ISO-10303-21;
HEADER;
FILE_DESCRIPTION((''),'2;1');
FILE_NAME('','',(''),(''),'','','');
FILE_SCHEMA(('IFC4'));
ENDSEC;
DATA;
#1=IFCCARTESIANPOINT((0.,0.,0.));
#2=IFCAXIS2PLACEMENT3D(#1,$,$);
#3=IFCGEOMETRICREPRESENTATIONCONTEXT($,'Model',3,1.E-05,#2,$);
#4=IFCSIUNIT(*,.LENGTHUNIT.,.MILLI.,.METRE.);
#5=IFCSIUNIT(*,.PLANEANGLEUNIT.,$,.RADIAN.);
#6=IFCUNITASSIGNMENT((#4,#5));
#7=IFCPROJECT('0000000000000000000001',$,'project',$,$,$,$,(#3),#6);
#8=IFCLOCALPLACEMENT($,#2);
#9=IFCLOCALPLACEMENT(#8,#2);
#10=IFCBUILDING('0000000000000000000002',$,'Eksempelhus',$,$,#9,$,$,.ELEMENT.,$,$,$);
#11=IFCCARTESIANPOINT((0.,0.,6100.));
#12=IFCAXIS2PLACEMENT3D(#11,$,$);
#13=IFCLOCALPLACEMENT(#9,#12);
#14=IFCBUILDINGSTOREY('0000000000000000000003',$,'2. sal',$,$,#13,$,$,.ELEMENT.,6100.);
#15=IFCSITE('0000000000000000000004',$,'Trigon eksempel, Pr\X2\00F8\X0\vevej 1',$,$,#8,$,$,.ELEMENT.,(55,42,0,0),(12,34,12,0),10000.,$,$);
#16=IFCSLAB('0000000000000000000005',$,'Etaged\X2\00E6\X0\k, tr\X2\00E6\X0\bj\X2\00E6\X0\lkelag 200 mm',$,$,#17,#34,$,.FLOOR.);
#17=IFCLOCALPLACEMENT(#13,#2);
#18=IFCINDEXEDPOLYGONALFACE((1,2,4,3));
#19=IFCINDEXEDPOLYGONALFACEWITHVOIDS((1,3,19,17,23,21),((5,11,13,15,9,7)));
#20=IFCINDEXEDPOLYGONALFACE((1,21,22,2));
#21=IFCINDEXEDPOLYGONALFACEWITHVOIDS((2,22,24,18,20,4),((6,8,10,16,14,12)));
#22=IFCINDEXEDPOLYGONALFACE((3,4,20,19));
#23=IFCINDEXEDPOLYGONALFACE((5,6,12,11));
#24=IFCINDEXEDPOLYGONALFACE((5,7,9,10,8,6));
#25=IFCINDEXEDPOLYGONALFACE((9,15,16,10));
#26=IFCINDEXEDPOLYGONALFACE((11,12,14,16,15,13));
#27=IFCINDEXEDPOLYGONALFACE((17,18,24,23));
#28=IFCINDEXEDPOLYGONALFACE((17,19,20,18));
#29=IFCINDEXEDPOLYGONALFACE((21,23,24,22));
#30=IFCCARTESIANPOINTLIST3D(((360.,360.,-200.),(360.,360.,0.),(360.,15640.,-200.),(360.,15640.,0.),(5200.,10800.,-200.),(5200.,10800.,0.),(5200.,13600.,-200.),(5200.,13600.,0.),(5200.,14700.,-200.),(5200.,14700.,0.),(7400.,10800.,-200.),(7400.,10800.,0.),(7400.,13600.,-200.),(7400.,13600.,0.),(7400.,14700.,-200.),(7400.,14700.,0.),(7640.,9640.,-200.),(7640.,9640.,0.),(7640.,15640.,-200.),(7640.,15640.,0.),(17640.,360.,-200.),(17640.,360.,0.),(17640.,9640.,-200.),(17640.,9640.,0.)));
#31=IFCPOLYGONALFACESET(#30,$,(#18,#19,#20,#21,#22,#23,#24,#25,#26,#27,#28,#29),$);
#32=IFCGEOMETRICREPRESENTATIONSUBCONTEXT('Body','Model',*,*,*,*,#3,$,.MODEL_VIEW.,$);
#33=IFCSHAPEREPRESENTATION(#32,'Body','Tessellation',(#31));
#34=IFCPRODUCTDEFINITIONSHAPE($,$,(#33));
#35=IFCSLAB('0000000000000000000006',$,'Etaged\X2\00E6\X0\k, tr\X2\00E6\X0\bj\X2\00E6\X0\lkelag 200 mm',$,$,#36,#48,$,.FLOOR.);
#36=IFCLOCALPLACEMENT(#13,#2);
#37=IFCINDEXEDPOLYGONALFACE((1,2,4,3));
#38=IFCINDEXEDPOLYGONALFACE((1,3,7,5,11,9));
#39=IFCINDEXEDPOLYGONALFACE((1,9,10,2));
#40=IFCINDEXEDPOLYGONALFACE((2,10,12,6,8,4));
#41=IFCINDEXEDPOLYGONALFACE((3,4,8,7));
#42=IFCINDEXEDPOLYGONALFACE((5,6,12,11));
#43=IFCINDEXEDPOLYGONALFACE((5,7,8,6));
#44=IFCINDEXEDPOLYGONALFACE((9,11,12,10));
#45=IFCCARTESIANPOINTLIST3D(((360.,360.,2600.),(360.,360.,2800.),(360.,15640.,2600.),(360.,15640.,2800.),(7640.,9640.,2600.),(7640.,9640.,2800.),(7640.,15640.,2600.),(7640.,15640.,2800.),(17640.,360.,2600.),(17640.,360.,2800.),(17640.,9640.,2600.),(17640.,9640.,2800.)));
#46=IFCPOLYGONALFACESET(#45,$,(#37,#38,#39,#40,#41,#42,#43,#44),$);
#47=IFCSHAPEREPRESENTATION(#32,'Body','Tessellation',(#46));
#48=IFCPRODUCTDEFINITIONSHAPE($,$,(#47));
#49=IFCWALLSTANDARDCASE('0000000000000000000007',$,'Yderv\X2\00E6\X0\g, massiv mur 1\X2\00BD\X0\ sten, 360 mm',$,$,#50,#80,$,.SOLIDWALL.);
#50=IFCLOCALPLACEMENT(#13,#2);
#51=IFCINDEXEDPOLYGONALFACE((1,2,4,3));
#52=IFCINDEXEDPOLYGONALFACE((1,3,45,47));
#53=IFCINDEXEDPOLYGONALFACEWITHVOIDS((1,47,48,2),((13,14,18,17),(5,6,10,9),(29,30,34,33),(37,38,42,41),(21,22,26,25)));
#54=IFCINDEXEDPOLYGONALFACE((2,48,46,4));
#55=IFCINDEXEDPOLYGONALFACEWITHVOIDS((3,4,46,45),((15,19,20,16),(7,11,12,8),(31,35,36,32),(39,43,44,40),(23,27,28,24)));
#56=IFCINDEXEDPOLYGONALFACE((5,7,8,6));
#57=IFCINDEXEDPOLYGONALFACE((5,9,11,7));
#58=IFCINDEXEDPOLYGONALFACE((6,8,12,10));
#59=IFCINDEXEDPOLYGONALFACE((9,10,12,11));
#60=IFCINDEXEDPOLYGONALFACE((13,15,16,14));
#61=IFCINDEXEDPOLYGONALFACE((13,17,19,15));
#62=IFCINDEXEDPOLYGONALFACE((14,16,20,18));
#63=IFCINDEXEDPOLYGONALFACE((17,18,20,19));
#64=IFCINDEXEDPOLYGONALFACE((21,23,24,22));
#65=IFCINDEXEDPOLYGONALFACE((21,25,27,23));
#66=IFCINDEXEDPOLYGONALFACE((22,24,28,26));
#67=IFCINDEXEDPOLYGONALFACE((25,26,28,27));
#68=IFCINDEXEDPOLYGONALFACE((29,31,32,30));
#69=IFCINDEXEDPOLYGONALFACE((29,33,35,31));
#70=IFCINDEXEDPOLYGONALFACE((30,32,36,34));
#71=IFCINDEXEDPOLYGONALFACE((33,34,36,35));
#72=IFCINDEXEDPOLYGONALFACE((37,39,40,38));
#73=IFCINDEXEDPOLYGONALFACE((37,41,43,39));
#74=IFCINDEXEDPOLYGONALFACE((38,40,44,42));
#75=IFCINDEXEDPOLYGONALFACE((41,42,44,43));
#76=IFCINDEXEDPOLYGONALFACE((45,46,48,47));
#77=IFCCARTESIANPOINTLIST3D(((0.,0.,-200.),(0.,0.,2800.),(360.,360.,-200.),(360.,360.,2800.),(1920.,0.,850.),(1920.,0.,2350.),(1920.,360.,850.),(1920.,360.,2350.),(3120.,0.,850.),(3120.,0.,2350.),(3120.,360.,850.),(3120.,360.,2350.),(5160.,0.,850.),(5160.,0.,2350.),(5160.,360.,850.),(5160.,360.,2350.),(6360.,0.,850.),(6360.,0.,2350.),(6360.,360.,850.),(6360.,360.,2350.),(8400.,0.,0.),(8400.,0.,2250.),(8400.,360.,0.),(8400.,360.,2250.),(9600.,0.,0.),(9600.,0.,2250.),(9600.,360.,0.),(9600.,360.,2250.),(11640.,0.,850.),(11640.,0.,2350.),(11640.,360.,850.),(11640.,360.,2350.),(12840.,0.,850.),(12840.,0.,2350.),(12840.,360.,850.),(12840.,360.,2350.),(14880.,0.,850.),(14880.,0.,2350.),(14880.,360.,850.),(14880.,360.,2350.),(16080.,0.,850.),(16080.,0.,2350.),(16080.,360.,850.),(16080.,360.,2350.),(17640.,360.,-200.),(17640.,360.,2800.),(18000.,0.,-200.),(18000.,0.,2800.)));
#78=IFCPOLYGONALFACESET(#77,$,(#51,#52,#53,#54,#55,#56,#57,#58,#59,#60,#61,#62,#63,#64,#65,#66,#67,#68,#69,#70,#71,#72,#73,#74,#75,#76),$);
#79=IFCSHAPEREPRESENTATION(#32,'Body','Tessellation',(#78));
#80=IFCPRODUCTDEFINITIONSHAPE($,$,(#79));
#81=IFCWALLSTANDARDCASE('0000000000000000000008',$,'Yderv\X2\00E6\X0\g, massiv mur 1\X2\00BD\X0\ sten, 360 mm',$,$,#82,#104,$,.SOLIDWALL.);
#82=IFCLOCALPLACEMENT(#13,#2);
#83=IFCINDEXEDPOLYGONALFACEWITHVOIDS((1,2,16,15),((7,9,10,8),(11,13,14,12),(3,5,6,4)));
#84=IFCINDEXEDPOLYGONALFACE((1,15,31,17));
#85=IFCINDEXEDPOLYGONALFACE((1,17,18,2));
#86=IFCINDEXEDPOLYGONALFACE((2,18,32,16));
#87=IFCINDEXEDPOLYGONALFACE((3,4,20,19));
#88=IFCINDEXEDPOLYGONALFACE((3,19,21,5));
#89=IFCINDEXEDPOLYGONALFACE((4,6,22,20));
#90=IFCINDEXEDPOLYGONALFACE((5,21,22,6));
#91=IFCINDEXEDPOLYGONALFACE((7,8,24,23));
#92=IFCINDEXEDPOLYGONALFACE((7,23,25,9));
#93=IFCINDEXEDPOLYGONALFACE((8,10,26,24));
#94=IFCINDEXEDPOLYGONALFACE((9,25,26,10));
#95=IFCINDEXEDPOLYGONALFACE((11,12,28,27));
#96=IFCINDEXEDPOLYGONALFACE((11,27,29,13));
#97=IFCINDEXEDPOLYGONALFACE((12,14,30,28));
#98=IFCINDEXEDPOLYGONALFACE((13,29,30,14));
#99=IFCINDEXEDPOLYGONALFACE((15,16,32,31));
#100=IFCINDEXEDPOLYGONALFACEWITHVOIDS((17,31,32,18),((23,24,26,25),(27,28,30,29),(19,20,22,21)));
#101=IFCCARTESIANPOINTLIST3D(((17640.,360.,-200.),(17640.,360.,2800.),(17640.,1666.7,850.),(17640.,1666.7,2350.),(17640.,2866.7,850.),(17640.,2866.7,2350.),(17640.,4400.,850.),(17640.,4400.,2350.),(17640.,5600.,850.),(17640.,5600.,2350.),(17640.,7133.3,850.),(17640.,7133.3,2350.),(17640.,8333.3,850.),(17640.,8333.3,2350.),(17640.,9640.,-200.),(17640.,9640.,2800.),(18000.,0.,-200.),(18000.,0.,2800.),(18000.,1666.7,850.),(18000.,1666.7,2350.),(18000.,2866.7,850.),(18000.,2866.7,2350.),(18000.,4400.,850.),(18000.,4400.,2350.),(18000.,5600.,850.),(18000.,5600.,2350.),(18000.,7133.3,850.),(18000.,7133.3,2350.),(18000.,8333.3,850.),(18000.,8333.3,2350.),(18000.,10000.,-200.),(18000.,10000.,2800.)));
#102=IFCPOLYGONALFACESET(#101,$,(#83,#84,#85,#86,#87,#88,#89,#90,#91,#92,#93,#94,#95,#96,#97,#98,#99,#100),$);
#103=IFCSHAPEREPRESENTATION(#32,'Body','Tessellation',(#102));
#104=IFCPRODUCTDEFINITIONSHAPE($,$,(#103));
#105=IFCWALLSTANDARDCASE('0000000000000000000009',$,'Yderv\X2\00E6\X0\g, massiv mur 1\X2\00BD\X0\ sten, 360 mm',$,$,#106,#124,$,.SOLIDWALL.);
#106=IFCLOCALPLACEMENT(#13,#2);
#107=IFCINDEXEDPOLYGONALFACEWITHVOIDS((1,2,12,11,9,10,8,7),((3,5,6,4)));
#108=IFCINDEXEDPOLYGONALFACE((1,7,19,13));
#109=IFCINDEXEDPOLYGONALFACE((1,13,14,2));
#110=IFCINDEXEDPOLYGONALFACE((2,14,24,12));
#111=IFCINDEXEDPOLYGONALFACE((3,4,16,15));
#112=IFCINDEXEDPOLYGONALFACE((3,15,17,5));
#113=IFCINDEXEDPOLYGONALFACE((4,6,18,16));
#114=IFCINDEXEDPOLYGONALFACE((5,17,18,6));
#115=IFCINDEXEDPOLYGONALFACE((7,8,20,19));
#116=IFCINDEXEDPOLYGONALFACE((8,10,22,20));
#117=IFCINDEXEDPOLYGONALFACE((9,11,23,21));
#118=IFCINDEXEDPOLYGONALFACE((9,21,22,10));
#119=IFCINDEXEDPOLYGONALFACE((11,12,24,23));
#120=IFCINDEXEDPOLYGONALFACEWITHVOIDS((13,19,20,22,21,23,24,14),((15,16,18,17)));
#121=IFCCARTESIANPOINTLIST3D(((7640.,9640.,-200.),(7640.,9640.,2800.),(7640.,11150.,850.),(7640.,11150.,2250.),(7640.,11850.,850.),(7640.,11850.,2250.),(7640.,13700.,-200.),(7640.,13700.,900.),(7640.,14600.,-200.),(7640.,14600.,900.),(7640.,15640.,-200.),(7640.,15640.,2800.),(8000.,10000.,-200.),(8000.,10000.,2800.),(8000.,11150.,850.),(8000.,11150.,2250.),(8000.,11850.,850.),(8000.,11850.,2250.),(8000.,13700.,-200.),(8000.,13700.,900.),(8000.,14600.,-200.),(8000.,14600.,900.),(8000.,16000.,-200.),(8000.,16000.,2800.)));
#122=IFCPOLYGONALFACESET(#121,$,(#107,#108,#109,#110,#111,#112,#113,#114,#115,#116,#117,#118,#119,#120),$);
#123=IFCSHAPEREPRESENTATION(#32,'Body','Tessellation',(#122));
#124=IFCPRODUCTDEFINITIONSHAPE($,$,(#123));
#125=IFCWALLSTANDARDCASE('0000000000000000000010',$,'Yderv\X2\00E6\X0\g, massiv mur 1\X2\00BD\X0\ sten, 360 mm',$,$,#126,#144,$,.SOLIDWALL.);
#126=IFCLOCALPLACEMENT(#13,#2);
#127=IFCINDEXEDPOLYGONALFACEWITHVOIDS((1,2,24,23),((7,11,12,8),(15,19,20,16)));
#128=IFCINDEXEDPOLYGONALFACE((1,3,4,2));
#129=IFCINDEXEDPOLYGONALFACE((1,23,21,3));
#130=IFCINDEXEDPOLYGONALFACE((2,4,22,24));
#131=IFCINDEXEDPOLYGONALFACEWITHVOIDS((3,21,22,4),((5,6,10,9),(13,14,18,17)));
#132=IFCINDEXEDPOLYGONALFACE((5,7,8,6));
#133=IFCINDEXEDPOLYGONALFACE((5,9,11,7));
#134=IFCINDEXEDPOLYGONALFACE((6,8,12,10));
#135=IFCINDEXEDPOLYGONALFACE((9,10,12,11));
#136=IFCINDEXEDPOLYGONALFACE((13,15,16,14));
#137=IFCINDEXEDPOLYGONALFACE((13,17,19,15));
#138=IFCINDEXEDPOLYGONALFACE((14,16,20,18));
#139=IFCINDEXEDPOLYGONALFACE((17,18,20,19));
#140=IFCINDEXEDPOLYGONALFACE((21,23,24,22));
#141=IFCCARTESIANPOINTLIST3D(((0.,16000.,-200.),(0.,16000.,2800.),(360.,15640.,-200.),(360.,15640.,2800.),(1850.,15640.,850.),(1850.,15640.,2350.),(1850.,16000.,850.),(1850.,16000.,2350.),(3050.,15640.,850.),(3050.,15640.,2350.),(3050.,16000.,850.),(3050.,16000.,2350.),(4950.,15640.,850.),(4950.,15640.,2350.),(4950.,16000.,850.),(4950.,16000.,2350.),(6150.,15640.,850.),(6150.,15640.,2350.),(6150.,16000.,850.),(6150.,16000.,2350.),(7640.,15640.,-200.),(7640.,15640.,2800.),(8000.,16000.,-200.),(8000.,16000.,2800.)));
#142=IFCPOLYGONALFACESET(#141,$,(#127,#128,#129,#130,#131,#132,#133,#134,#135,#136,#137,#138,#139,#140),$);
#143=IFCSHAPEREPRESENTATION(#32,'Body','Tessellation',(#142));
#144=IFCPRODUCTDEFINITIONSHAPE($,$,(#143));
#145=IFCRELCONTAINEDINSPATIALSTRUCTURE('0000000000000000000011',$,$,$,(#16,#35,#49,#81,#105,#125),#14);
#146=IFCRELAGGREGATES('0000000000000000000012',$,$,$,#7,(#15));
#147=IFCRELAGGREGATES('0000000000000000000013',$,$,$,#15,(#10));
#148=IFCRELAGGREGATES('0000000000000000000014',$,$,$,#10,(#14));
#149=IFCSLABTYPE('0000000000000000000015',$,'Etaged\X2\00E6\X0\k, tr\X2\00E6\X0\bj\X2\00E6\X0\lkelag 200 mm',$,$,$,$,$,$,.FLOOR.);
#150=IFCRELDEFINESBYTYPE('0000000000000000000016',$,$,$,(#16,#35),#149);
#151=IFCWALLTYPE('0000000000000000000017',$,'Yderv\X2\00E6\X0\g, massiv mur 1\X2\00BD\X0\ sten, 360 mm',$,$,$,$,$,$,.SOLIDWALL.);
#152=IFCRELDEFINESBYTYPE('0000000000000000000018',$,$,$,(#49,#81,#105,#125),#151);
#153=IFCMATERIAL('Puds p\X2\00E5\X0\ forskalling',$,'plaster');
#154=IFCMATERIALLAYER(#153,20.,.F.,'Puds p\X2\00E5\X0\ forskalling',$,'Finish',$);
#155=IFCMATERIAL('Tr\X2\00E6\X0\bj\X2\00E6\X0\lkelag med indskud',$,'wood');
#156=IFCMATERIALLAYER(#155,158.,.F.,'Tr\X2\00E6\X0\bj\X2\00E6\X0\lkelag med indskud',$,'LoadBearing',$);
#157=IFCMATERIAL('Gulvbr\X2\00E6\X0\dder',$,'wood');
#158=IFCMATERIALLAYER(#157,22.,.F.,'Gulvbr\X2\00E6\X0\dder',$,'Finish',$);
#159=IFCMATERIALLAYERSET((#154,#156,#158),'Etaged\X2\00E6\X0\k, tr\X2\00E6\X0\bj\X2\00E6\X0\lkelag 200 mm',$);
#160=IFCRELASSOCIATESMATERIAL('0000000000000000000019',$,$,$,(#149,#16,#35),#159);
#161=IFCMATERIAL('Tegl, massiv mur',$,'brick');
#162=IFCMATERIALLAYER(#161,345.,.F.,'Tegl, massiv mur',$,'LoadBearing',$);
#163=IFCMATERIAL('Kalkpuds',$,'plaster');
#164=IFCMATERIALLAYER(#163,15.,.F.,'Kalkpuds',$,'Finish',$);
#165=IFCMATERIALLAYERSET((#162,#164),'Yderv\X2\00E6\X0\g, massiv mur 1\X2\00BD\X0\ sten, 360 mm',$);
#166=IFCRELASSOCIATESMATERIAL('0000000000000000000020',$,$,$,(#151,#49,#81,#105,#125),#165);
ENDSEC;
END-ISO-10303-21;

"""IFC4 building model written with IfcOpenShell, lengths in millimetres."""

from ifc_helpers import new_model, si_unit, frame, origin, place, context, subcontext, project, spatial, polyline, rectangle, outline, extrude, material, layer, layer_set, layer_usage, type_object, element, save


model = new_model("IFC4")

# Units and contexts
model_context = context("Model", 3, precision=1e-05, world=origin())
body_context = subcontext(model_context, "Body", "Model", "MODEL_VIEW")
ifc_project = project(units=[si_unit("LENGTHUNIT", "METRE", prefix="MILLI"), si_unit("PLANEANGLEUNIT", "RADIAN")], contexts=[model_context])

# Site, building, storey
site_placement = place(None, origin())
site = spatial("IfcSite", under=ifc_project, at=site_placement, Name="Trigon eksempel, Prøvevej 1", CompositionType="ELEMENT", RefLatitude=(55, 42, 0, 0), RefLongitude=(12, 34, 12, 0), RefElevation=10000.0)
building_placement = place(site_placement, origin())
building = spatial("IfcBuilding", under=site, at=building_placement, Name="Eksempelhus", CompositionType="ELEMENT")
storey_placement = place(building_placement, frame((0.0, 0.0, 6100.0)))
storey = spatial("IfcBuildingStorey", under=building, at=storey_placement, Name="2. sal", CompositionType="ELEMENT", Elevation=6100.0)

# Slabs
ifc_material_1 = material(Name="Puds på forskalling", Category="plaster")
ifc_layer_1 = layer(ifc_material_1, 20.0, ventilated=False, Name="Puds på forskalling", Category="Finish")
ifc_material_2 = material(Name="Træbjælkelag med indskud", Category="wood")
ifc_layer_2 = layer(ifc_material_2, 158.0, ventilated=False, Name="Træbjælkelag med indskud", Category="LoadBearing")
ifc_material_3 = material(Name="Gulvbrædder", Category="wood")
ifc_layer_3 = layer(ifc_material_3, 22.0, ventilated=False, Name="Gulvbrædder", Category="Finish")
ifc_layer_set_1 = layer_set([ifc_layer_1, ifc_layer_2, ifc_layer_3], Name="Etagedæk, træbjælkelag 200 mm")
ifc_layer_usage_1 = layer_usage(ifc_layer_set_1, "AXIS3", "POSITIVE", 0.0)
slab_type = type_object("IfcSlabType", Name="Etagedæk, træbjælkelag 200 mm", PredefinedType="FLOOR", material=ifc_layer_set_1)
slab_1_placement = place(storey_placement, frame((0.0, 0.0, -200.0)))
element("IfcSlab", 1, at=slab_1_placement, inside=storey, type_object=slab_type, material=ifc_layer_usage_1, Name="Etagedæk, træbjælkelag 200 mm", PredefinedType="FLOOR", context=body_context, shape_type="SweptSolid", body=[
    extrude(outline(polyline([(360.0, 360.0), (17640.0, 360.0), (17640.0, 9640.0), (7640.0, 9640.0), (7640.0, 15640.0), (360.0, 15640.0), (360.0, 360.0)]), holes=[polyline([(7400.0, 10800.0), (7400.0, 13600.0), (7400.0, 14700.0), (5200.0, 14700.0), (5200.0, 13600.0), (5200.0, 10800.0), (7400.0, 10800.0)])]), origin(), (0.0, 0.0, 1.0), 200.0),
])
slab_2_placement = place(storey_placement, frame((0.0, 0.0, 2600.0)))
element("IfcSlab", 2, at=slab_2_placement, inside=storey, type_object=slab_type, material=ifc_layer_usage_1, Name="Etagedæk, træbjælkelag 200 mm", PredefinedType="FLOOR", context=body_context, shape_type="SweptSolid", body=[
    extrude(outline(polyline([(360.0, 360.0), (17640.0, 360.0), (17640.0, 9640.0), (7640.0, 9640.0), (7640.0, 15640.0), (360.0, 15640.0), (360.0, 360.0)])), origin(), (0.0, 0.0, 1.0), 200.0),
])

# Walls, openings
ifc_material_4 = material(Name="Tegl, massiv mur", Category="brick")
ifc_layer_4 = layer(ifc_material_4, 345.0, ventilated=False, Name="Tegl, massiv mur", Category="LoadBearing")
ifc_material_5 = material(Name="Kalkpuds", Category="plaster")
ifc_layer_5 = layer(ifc_material_5, 15.0, ventilated=False, Name="Kalkpuds", Category="Finish")
ifc_layer_set_2 = layer_set([ifc_layer_4, ifc_layer_5], Name="Ydervæg, massiv mur 1½ sten, 360 mm")
ifc_layer_usage_2 = layer_usage(ifc_layer_set_2, "AXIS2", "POSITIVE", 0.0)
wall_type_1 = type_object("IfcWallType", Name="Ydervæg, massiv mur 1½ sten, 360 mm", PredefinedType="SOLIDWALL", material=ifc_layer_set_2)
wall_1_placement = place(storey_placement, frame((0.0, 0.0, -200.0)))
wall_1 = element("IfcWallStandardCase", 3, at=wall_1_placement, inside=storey, type_object=wall_type_1, material=ifc_layer_usage_2, Name="Ydervæg, massiv mur 1½ sten, 360 mm", PredefinedType="SOLIDWALL", context=body_context, shape_type="SweptSolid", body=[
    extrude(outline(polyline([(0.0, 0.0), (18000.0, 0.0), (17640.0, 360.0), (360.0, 360.0), (0.0, 0.0)])), origin(), (0.0, 0.0, 1.0), 3000.0),
])
opening_1_placement = place(wall_1_placement, frame((1920.0, 0.0, 1050.0)))
element("IfcOpeningElement", 4, at=opening_1_placement, cuts=wall_1, PredefinedType="OPENING", context=body_context, shape_type="SweptSolid", body=[
    extrude(rectangle(XDim=1200.0, YDim=1500.0), frame((600.0, 0.0, 750.0), z_axis=(0.0, 1.0, 0.0), x_axis=(1.0, 0.0, 0.0)), (0.0, 0.0, 1.0), 360.0),
])
opening_2_placement = place(wall_1_placement, frame((5160.0, 0.0, 1050.0)))
element("IfcOpeningElement", 5, at=opening_2_placement, cuts=wall_1, PredefinedType="OPENING", context=body_context, shape_type="SweptSolid", body=[
    extrude(rectangle(XDim=1200.0, YDim=1500.0), frame((600.0, 0.0, 750.0), z_axis=(0.0, 1.0, 0.0), x_axis=(1.0, 0.0, 0.0)), (0.0, 0.0, 1.0), 360.0),
])
opening_3_placement = place(wall_1_placement, frame((11640.0, 0.0, 1050.0)))
element("IfcOpeningElement", 6, at=opening_3_placement, cuts=wall_1, PredefinedType="OPENING", context=body_context, shape_type="SweptSolid", body=[
    extrude(rectangle(XDim=1200.0, YDim=1500.0), frame((600.0, 0.0, 750.0), z_axis=(0.0, 1.0, 0.0), x_axis=(1.0, 0.0, 0.0)), (0.0, 0.0, 1.0), 360.0),
])
opening_4_placement = place(wall_1_placement, frame((14880.0, 0.0, 1050.0)))
element("IfcOpeningElement", 7, at=opening_4_placement, cuts=wall_1, PredefinedType="OPENING", context=body_context, shape_type="SweptSolid", body=[
    extrude(rectangle(XDim=1200.0, YDim=1500.0), frame((600.0, 0.0, 750.0), z_axis=(0.0, 1.0, 0.0), x_axis=(1.0, 0.0, 0.0)), (0.0, 0.0, 1.0), 360.0),
])
opening_5_placement = place(wall_1_placement, frame((8400.0, 0.0, 200.0)))
element("IfcOpeningElement", 8, at=opening_5_placement, cuts=wall_1, PredefinedType="OPENING", context=body_context, shape_type="SweptSolid", body=[
    extrude(rectangle(XDim=1200.0, YDim=2250.0), frame((600.0, 0.0, 1125.0), z_axis=(0.0, 1.0, 0.0), x_axis=(1.0, 0.0, 0.0)), (0.0, 0.0, 1.0), 360.0),
])
wall_2_placement = place(storey_placement, frame((18000.0, 0.0, -200.0), z_axis=(0.0, 0.0, 1.0), x_axis=(0.0, 1.0, 0.0)))
wall_2 = element("IfcWallStandardCase", 9, at=wall_2_placement, inside=storey, type_object=wall_type_1, material=ifc_layer_usage_2, Name="Ydervæg, massiv mur 1½ sten, 360 mm", PredefinedType="SOLIDWALL", context=body_context, shape_type="SweptSolid", body=[
    extrude(outline(polyline([(0.0, 0.0), (10000.0, 0.0), (9640.0, 360.0), (360.0, 360.0), (0.0, 0.0)])), origin(), (0.0, 0.0, 1.0), 3000.0),
])
opening_6_placement = place(wall_2_placement, frame((1666.7, 0.0, 1050.0)))
element("IfcOpeningElement", 10, at=opening_6_placement, cuts=wall_2, PredefinedType="OPENING", context=body_context, shape_type="SweptSolid", body=[
    extrude(rectangle(XDim=1200.0, YDim=1500.0), frame((600.0, 0.0, 750.0), z_axis=(0.0, 1.0, 0.0), x_axis=(1.0, 0.0, 0.0)), (0.0, 0.0, 1.0), 360.0),
])
opening_7_placement = place(wall_2_placement, frame((4400.0, 0.0, 1050.0)))
element("IfcOpeningElement", 11, at=opening_7_placement, cuts=wall_2, PredefinedType="OPENING", context=body_context, shape_type="SweptSolid", body=[
    extrude(rectangle(XDim=1200.0, YDim=1500.0), frame((600.0, 0.0, 750.0), z_axis=(0.0, 1.0, 0.0), x_axis=(1.0, 0.0, 0.0)), (0.0, 0.0, 1.0), 360.0),
])
opening_8_placement = place(wall_2_placement, frame((7133.3, 0.0, 1050.0)))
element("IfcOpeningElement", 12, at=opening_8_placement, cuts=wall_2, PredefinedType="OPENING", context=body_context, shape_type="SweptSolid", body=[
    extrude(rectangle(XDim=1200.0, YDim=1500.0), frame((600.0, 0.0, 750.0), z_axis=(0.0, 1.0, 0.0), x_axis=(1.0, 0.0, 0.0)), (0.0, 0.0, 1.0), 360.0),
])
wall_3_placement = place(storey_placement, frame((8000.0, 10000.0, -200.0), z_axis=(0.0, 0.0, 1.0), x_axis=(0.0, 1.0, 0.0)))
wall_3 = element("IfcWallStandardCase", 13, at=wall_3_placement, inside=storey, type_object=wall_type_1, material=ifc_layer_usage_2, Name="Ydervæg, massiv mur 1½ sten, 360 mm", PredefinedType="SOLIDWALL", context=body_context, shape_type="SweptSolid", body=[
    extrude(outline(polyline([(0.0, 0.0), (6000.0, 0.0), (5640.0, 360.0), (-360.0, 360.0), (0.0, 0.0)])), origin(), (0.0, 0.0, 1.0), 3000.0),
])
opening_9_placement = place(wall_3_placement, frame((1150.0, 0.0, 1050.0)))
element("IfcOpeningElement", 14, at=opening_9_placement, cuts=wall_3, PredefinedType="OPENING", context=body_context, shape_type="SweptSolid", body=[
    extrude(rectangle(XDim=700.0, YDim=1400.0), frame((350.0, 0.0, 700.0), z_axis=(0.0, 1.0, 0.0), x_axis=(1.0, 0.0, 0.0)), (0.0, 0.0, 1.0), 360.0),
])
opening_10_placement = place(wall_3_placement, frame((3700.0, 0.0, 0.0)))
element("IfcOpeningElement", 15, at=opening_10_placement, cuts=wall_3, PredefinedType="OPENING", context=body_context, shape_type="SweptSolid", body=[
    extrude(rectangle(XDim=900.0, YDim=1100.0), frame((450.0, 0.0, 550.0), z_axis=(0.0, 1.0, 0.0), x_axis=(1.0, 0.0, 0.0)), (0.0, 0.0, 1.0), 360.0),
])
wall_4_placement = place(storey_placement, frame((8000.0, 16000.0, -200.0), z_axis=(0.0, 0.0, 1.0), x_axis=(-1.0, 0.0, 0.0)))
wall_4 = element("IfcWallStandardCase", 16, at=wall_4_placement, inside=storey, type_object=wall_type_1, material=ifc_layer_usage_2, Name="Ydervæg, massiv mur 1½ sten, 360 mm", PredefinedType="SOLIDWALL", context=body_context, shape_type="SweptSolid", body=[
    extrude(outline(polyline([(0.0, 0.0), (8000.0, 0.0), (7640.0, 360.0), (360.0, 360.0), (0.0, 0.0)])), origin(), (0.0, 0.0, 1.0), 3000.0),
])
opening_11_placement = place(wall_4_placement, frame((1850.0, 0.0, 1050.0)))
element("IfcOpeningElement", 17, at=opening_11_placement, cuts=wall_4, PredefinedType="OPENING", context=body_context, shape_type="SweptSolid", body=[
    extrude(rectangle(XDim=1200.0, YDim=1500.0), frame((600.0, 0.0, 750.0), z_axis=(0.0, 1.0, 0.0), x_axis=(1.0, 0.0, 0.0)), (0.0, 0.0, 1.0), 360.0),
])
opening_12_placement = place(wall_4_placement, frame((4950.0, 0.0, 1050.0)))
element("IfcOpeningElement", 18, at=opening_12_placement, cuts=wall_4, PredefinedType="OPENING", context=body_context, shape_type="SweptSolid", body=[
    extrude(rectangle(XDim=1200.0, YDim=1500.0), frame((600.0, 0.0, 750.0), z_axis=(0.0, 1.0, 0.0), x_axis=(1.0, 0.0, 0.0)), (0.0, 0.0, 1.0), 360.0),
])

save(model, "model.ifc")
